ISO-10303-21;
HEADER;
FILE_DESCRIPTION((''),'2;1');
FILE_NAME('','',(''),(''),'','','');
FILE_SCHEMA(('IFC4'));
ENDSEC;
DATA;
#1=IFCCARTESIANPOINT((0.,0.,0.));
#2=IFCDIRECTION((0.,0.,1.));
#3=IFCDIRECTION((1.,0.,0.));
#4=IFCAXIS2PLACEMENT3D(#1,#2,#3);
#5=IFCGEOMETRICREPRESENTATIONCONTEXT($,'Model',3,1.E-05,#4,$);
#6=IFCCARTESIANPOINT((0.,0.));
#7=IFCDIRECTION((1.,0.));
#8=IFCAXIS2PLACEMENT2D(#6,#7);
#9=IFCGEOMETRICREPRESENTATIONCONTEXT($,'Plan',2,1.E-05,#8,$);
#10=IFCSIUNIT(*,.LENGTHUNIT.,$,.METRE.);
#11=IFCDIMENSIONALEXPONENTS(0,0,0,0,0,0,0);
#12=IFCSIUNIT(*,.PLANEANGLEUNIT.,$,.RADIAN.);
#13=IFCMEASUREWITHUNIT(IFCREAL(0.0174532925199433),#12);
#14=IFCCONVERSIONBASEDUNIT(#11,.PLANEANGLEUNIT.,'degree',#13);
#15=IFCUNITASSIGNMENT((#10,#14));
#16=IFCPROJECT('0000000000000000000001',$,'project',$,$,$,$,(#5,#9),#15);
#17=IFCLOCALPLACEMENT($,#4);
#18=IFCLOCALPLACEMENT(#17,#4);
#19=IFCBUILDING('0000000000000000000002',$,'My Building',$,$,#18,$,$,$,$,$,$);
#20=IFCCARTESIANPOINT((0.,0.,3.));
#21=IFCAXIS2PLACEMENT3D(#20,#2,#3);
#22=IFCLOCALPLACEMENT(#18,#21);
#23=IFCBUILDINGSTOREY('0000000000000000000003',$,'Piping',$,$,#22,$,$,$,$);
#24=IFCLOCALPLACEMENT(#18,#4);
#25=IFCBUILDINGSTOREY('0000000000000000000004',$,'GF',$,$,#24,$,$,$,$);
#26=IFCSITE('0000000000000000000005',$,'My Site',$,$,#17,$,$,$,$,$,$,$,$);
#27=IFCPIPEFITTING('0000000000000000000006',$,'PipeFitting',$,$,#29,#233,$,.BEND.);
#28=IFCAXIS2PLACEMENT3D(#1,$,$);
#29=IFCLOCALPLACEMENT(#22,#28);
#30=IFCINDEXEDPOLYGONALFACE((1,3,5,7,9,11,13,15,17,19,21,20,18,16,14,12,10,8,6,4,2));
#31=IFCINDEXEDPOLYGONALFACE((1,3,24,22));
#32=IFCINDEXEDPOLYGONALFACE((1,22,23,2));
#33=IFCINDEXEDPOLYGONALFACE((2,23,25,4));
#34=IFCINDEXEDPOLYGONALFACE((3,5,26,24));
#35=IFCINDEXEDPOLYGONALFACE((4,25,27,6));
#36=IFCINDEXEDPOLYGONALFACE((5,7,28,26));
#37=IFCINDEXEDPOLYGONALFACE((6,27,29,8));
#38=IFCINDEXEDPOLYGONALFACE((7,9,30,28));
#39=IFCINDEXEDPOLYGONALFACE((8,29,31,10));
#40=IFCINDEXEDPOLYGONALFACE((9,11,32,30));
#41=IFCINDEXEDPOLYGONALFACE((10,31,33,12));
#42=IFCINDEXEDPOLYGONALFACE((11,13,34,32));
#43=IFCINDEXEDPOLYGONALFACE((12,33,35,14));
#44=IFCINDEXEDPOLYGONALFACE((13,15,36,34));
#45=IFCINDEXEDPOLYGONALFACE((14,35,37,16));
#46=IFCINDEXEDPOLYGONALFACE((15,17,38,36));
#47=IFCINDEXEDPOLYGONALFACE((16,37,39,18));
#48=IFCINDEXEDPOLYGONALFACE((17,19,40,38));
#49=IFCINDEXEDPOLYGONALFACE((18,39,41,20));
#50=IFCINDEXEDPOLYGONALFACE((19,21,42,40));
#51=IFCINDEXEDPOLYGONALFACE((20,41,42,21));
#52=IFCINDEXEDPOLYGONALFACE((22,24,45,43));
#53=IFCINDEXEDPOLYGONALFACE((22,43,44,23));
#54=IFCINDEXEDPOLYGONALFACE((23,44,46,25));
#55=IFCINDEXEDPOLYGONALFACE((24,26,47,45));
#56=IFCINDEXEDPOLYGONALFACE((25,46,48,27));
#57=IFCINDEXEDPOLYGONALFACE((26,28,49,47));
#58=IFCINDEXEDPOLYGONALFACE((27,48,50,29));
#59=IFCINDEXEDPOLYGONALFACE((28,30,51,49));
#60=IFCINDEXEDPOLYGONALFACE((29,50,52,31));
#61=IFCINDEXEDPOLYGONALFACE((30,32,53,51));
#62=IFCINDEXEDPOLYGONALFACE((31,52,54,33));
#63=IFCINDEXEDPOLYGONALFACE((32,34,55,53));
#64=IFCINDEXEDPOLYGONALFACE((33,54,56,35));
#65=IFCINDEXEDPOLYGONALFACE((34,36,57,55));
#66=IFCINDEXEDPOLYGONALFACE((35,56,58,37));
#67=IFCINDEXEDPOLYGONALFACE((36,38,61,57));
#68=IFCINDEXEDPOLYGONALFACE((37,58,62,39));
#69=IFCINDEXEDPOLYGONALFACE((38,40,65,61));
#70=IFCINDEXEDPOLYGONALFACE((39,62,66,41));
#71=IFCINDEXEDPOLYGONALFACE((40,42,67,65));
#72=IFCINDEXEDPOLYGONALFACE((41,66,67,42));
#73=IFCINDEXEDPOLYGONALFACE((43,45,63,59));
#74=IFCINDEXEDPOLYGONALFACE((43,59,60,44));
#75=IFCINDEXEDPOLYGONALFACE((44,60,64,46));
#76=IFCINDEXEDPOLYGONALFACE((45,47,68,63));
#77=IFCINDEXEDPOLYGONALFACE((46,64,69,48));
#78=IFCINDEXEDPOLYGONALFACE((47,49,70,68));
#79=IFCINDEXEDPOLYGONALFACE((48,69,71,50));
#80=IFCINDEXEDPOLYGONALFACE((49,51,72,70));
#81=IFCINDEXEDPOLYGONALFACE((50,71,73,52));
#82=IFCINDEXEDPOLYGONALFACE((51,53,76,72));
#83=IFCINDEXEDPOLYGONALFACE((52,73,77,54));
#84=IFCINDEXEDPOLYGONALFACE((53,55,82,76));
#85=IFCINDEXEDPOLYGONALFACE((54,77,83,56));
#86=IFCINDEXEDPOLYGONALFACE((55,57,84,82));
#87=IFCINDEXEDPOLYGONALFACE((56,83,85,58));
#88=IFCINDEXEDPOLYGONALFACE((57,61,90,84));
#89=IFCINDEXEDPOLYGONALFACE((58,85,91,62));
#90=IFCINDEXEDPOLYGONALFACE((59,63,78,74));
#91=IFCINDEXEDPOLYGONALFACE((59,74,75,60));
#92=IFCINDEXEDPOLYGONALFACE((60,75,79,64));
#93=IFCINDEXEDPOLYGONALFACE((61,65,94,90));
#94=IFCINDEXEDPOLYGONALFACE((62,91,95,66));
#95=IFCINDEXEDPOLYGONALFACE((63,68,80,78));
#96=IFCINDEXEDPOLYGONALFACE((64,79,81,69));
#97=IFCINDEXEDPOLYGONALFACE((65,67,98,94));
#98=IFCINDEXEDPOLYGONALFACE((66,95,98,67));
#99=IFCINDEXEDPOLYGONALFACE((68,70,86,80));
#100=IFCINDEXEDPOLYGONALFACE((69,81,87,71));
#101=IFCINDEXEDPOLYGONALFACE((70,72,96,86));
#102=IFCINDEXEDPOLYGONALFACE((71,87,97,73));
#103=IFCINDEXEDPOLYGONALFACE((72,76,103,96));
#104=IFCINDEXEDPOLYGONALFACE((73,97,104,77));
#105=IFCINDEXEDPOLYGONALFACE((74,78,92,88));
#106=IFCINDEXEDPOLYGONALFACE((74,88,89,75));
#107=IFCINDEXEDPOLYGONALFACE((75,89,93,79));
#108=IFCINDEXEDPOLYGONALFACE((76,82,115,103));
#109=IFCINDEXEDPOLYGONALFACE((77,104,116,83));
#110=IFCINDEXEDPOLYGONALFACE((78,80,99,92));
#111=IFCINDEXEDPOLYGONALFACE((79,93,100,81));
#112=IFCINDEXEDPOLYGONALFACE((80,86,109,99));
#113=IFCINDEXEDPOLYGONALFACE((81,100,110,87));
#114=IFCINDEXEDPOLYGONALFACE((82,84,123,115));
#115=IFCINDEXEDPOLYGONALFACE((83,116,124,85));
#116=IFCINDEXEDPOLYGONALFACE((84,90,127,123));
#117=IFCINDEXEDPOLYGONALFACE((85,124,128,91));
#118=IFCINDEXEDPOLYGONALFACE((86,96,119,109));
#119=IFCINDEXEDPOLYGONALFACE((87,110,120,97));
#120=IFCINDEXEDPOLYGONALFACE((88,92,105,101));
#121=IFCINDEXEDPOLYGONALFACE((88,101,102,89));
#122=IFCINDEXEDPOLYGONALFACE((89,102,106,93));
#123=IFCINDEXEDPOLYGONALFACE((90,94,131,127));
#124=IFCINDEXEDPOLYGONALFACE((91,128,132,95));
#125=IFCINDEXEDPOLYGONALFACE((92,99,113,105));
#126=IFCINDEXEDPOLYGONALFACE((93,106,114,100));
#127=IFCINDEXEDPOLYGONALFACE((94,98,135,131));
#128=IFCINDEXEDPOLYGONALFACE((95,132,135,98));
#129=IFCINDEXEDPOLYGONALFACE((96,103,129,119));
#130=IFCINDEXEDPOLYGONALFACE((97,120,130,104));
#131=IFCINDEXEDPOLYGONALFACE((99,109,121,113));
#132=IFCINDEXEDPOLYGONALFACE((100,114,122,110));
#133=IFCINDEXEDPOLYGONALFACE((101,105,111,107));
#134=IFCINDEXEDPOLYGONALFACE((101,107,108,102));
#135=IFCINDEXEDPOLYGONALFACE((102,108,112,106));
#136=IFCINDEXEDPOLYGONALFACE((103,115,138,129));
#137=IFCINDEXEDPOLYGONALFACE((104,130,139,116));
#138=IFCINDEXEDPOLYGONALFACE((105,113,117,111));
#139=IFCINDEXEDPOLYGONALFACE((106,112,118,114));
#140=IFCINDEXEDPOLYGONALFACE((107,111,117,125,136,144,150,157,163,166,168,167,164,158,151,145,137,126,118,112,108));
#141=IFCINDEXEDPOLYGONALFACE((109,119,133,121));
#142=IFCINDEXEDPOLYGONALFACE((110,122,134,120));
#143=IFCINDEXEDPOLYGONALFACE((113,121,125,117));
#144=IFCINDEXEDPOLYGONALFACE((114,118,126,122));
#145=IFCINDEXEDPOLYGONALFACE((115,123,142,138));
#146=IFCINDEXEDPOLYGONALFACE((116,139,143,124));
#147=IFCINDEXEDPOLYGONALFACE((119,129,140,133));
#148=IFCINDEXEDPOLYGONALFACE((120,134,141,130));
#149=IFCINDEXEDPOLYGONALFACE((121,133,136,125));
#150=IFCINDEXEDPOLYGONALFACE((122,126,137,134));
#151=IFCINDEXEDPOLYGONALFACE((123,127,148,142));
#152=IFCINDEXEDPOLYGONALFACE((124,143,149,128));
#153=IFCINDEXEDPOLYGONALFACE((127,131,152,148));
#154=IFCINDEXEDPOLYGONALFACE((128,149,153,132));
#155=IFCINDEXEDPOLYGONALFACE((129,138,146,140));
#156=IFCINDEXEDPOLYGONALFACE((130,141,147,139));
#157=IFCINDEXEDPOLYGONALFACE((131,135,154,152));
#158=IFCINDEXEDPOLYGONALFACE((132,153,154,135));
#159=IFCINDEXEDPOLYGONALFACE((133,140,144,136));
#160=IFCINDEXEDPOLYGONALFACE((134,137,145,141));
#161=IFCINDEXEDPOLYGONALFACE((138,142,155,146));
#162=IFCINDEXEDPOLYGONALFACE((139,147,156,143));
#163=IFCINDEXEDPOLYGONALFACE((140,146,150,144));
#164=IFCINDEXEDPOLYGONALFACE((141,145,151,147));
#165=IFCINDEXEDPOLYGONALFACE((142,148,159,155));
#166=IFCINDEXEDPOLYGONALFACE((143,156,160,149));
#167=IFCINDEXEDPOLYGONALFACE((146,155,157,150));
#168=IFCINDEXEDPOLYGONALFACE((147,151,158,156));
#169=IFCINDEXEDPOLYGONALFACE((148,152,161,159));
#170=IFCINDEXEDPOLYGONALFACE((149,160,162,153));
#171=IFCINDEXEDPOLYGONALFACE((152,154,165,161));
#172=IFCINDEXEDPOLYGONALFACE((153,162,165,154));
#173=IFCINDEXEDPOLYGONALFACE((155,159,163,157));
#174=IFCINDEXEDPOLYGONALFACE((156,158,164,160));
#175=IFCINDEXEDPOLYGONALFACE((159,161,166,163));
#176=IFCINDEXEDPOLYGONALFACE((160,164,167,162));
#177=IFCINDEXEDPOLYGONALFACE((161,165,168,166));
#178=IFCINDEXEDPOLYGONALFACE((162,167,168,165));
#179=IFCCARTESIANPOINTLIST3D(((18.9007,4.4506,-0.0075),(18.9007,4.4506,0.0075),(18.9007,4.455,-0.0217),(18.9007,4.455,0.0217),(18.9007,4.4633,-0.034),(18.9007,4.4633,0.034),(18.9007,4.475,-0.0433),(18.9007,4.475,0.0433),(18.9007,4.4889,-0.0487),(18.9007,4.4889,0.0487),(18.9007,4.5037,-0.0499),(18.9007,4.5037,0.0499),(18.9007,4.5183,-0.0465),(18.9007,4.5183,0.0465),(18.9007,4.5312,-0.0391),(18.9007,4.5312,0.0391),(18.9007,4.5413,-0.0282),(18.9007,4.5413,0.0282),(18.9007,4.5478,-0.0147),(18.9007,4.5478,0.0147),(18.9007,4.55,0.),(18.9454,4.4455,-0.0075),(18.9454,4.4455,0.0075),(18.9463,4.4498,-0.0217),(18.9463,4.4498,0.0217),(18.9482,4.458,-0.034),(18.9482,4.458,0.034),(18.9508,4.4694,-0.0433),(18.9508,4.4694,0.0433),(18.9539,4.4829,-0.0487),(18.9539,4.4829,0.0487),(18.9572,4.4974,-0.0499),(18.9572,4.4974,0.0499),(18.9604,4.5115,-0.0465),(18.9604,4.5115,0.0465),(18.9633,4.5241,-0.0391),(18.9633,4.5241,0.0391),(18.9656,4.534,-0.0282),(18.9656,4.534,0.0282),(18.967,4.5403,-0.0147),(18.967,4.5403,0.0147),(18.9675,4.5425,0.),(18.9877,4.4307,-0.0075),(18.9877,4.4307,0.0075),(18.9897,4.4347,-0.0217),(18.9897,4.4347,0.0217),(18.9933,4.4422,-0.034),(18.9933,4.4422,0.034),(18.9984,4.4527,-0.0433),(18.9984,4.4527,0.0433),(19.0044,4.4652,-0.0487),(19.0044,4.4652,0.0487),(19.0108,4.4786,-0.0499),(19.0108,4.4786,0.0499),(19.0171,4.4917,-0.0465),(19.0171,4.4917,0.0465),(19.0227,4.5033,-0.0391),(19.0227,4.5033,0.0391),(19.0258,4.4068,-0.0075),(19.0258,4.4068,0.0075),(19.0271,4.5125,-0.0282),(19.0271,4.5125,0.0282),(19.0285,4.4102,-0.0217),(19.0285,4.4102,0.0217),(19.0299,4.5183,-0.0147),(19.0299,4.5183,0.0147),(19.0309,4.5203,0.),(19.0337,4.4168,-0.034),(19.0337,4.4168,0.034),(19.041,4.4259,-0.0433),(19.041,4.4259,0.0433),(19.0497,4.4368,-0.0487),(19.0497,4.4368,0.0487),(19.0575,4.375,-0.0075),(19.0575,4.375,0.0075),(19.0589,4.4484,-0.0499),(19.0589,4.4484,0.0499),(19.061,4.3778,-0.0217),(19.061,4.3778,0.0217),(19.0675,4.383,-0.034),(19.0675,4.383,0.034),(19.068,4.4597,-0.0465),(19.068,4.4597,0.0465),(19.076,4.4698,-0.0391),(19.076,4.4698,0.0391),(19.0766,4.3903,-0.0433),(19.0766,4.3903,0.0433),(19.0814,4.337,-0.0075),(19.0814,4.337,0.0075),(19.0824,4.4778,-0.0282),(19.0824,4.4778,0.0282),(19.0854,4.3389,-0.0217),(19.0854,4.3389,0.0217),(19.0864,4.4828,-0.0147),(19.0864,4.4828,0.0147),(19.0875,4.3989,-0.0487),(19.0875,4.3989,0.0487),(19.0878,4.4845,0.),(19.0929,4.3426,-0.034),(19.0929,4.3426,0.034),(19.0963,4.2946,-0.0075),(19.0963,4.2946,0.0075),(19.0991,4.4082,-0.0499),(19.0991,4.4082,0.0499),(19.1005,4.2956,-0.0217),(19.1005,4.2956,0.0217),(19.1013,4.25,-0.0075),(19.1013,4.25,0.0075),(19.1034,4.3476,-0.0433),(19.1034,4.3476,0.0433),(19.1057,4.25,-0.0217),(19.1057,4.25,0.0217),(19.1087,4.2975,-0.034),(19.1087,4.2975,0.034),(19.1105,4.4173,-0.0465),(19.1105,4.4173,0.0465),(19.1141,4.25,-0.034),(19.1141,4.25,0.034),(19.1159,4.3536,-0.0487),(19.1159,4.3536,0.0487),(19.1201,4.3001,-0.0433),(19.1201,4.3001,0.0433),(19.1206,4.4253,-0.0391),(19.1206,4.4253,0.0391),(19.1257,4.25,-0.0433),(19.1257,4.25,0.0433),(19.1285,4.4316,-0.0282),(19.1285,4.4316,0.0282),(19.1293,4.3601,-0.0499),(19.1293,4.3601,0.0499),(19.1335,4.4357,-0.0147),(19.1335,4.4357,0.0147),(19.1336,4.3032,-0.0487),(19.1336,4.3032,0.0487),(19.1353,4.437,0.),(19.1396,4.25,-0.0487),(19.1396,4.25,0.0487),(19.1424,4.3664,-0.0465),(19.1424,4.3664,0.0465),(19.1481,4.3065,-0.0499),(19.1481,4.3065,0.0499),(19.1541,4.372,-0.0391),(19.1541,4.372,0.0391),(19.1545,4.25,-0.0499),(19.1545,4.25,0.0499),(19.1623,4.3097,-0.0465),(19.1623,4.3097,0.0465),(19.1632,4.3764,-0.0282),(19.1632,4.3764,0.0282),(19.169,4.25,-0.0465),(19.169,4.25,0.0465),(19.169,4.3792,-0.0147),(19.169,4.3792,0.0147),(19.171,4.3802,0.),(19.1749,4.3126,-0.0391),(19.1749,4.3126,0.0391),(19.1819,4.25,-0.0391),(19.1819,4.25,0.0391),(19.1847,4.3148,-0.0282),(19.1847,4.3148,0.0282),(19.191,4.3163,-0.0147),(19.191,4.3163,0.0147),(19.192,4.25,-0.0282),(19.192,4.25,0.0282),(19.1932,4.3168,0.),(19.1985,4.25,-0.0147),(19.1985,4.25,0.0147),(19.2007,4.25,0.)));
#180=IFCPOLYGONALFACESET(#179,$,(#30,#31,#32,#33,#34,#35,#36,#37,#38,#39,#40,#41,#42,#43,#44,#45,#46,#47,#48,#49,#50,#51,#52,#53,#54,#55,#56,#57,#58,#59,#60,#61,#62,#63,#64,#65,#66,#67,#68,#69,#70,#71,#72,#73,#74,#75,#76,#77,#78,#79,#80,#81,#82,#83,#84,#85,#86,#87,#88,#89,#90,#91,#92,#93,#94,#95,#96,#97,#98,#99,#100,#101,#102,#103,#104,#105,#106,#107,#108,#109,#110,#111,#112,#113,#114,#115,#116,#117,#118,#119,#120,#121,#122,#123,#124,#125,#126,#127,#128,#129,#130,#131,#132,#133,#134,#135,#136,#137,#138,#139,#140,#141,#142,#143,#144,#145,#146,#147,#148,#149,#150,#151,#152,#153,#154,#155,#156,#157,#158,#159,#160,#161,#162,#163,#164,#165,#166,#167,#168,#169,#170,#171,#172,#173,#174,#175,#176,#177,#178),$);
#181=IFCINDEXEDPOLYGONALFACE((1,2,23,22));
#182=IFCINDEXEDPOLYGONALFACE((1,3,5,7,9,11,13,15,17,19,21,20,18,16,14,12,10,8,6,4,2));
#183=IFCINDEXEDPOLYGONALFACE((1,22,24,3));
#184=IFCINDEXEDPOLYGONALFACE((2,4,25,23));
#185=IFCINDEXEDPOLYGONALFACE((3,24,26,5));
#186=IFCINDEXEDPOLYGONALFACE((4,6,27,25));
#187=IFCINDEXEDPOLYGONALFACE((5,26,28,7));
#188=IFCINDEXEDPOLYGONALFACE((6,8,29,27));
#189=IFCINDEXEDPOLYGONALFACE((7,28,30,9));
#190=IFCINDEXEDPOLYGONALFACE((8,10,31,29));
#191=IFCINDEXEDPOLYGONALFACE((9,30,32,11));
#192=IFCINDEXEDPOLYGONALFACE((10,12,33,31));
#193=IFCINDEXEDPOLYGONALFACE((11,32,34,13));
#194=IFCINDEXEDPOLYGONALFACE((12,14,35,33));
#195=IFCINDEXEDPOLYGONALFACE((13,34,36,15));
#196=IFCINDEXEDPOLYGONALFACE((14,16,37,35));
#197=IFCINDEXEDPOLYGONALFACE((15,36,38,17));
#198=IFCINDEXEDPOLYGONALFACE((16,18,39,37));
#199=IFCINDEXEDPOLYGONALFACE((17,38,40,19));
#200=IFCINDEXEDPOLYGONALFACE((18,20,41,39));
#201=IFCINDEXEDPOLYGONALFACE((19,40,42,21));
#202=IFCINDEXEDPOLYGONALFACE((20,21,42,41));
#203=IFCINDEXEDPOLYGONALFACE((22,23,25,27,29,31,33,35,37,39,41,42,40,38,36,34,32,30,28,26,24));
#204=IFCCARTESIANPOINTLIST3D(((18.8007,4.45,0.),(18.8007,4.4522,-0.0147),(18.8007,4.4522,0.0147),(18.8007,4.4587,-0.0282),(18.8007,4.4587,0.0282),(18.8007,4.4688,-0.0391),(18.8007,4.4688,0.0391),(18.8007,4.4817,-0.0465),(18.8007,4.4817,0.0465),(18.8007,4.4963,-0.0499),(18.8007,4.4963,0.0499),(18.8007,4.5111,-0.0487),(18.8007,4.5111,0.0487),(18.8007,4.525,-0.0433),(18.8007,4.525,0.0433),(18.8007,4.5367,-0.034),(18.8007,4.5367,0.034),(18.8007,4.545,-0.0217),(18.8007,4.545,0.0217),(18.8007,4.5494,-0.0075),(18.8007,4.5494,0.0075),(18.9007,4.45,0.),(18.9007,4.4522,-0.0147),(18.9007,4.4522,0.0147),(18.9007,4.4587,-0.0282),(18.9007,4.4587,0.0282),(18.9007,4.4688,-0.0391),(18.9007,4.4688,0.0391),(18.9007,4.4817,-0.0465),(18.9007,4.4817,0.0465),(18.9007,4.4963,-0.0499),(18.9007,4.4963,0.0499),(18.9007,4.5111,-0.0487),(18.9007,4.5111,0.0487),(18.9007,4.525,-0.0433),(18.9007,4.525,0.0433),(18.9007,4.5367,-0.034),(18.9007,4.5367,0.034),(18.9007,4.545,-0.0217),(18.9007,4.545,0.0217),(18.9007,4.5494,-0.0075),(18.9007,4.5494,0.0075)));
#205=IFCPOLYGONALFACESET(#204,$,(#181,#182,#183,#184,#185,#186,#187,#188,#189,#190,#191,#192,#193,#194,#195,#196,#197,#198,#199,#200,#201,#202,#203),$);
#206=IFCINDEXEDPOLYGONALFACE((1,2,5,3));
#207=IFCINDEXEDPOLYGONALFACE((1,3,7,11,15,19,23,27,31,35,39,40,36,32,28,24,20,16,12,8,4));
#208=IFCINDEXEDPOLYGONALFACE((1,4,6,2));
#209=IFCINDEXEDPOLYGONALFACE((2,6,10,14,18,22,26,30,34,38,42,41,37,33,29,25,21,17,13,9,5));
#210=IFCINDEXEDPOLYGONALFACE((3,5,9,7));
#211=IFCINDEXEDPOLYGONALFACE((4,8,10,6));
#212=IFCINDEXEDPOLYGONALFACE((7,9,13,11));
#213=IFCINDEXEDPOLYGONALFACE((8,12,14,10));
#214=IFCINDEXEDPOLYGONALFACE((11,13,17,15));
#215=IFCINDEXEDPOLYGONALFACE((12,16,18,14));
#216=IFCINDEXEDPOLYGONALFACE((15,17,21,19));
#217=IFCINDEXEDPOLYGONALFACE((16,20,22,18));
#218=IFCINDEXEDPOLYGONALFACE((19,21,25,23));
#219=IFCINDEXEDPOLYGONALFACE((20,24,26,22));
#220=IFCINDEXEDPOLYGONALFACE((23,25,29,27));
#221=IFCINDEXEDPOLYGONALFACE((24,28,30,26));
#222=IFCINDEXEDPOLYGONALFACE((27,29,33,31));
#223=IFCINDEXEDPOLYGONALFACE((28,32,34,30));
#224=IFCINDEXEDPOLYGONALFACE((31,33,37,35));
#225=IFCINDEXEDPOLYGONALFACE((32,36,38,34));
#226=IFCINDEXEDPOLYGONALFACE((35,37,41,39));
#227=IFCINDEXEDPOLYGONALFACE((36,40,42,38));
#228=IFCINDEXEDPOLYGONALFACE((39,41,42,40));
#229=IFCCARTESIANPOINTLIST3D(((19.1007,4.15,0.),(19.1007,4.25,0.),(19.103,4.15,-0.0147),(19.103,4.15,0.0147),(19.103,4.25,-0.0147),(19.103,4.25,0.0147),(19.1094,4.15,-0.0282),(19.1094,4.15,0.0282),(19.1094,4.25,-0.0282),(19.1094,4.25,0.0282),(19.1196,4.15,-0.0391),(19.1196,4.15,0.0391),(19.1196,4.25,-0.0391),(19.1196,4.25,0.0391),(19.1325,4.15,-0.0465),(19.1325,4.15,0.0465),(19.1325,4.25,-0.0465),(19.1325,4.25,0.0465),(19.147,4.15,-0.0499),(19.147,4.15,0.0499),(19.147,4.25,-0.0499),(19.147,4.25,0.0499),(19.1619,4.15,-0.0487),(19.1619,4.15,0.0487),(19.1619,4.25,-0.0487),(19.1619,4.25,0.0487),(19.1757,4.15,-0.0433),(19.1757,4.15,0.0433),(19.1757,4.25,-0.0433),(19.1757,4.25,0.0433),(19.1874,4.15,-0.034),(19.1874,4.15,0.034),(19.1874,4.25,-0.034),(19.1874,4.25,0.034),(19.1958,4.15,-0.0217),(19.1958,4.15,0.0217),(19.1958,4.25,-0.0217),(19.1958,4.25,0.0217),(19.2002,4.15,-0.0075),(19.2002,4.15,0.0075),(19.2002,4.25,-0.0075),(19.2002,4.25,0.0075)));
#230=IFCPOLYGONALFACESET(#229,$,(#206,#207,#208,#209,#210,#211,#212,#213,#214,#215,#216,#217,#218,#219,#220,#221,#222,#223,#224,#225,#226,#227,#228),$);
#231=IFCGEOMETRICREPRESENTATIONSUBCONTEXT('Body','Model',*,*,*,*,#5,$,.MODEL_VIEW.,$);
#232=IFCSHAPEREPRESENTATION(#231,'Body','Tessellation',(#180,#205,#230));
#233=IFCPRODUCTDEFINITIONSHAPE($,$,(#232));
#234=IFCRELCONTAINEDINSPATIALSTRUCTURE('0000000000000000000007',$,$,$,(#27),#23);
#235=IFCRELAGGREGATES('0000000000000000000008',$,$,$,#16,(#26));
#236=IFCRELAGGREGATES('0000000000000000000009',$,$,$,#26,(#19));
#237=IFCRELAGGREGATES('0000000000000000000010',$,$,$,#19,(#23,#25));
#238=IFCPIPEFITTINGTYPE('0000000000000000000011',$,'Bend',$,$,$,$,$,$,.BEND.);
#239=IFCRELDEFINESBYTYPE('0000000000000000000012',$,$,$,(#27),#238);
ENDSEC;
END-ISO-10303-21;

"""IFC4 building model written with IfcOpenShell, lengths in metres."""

from ifc_helpers import new_model, entity, si_unit, converted_unit, frame, origin_with_axes, origin_2d_with_axis, place, context, subcontext, project, spatial, circle, extrude, source, transform, mapped, type_object, type_shapes, element, save


model = new_model("IFC4")

# Units and contexts
model_context = context("Model", 3, precision=1e-05, world=origin_with_axes())
plan_context = context("Plan", 2, precision=1e-05, world=origin_2d_with_axis())
body_context_1 = subcontext(model_context, "Body", "Model", "MODEL_VIEW")
ifc_project = project(units=[si_unit("LENGTHUNIT", "METRE"), converted_unit("PLANEANGLEUNIT", "degree", entity("IfcReal", 0.0174532925199433), si_unit("PLANEANGLEUNIT", "RADIAN"), dimensions=[0, 0, 0, 0, 0, 0, 0])], contexts=[model_context, plan_context])

# Site, building, storey
site_placement = place(None, origin_with_axes())
site = spatial("IfcSite", under=ifc_project, at=site_placement, Name="My Site")
building_placement = place(site_placement, origin_with_axes())
building = spatial("IfcBuilding", under=site, at=building_placement, Name="My Building")
storey_1_placement = place(building_placement, frame((0.0, 0.0, 3.0), z_axis=(0.0, 0.0, 1.0), x_axis=(1.0, 0.0, 0.0)))
storey_1 = spatial("IfcBuildingStorey", under=building, at=storey_1_placement, Name="Piping")

# Shared definitions
storey_2_placement = place(building_placement, origin_with_axes())
storey_2 = spatial("IfcBuildingStorey", under=building, at=storey_2_placement, Name="GF")

# Pipe fitting
pipe_fitting_type_1 = type_object("IfcPipeFittingType", Name="Bend", PredefinedType="BEND")
shared_shape_1 = source(origin_with_axes(), body_context_1, "Body", "SolidModel", [
    entity("IfcSweptDiskSolid", entity("IfcIndexedPolyCurve", entity("IfcCartesianPointList3D", [[0.0, 0.0, -0.1], [0.0732, 0.0, -0.2768], [0.25, 0.0, -0.35]]), [entity("IfcArcIndex", [1, 2, 3])]), 0.05),
    extrude(circle(Radius=0.05), origin_with_axes(), (0.0, 0.0, -1.0), 0.1),
    extrude(circle(Radius=0.05), frame((0.25, 0.0, -0.35), z_axis=(1.0, 0.0, 0.0), x_axis=(0.0, 0.0, 1.0)), (0.0, 0.0, 1.0), 0.1),
])
type_shapes(pipe_fitting_type_1, [shared_shape_1])
for number, where, z_axis, x_axis, name in (
    (1, (18.8007, 4.5, 0.0), (-1.0, 0.0, 0.0), (0.0, -1.0, 0.0), "PipeFitting"),
):
    element("IfcPipeFitting", number, at=place(storey_1_placement, frame(where, z_axis=z_axis, x_axis=x_axis)), inside=storey_1, type_object=pipe_fitting_type_1, Name=name, PredefinedType="BEND", context=body_context_1, shape_type="MappedRepresentation", body=[
        mapped(shared_shape_1, transform((0.0, 0.0, 0.0), x_axis=(1.0, 0.0, 0.0), y_axis=(0.0, 1.0, 0.0), z_axis=(0.0, 0.0, 1.0), scale=1.0)),
    ])

save(model, "model.ifc")
